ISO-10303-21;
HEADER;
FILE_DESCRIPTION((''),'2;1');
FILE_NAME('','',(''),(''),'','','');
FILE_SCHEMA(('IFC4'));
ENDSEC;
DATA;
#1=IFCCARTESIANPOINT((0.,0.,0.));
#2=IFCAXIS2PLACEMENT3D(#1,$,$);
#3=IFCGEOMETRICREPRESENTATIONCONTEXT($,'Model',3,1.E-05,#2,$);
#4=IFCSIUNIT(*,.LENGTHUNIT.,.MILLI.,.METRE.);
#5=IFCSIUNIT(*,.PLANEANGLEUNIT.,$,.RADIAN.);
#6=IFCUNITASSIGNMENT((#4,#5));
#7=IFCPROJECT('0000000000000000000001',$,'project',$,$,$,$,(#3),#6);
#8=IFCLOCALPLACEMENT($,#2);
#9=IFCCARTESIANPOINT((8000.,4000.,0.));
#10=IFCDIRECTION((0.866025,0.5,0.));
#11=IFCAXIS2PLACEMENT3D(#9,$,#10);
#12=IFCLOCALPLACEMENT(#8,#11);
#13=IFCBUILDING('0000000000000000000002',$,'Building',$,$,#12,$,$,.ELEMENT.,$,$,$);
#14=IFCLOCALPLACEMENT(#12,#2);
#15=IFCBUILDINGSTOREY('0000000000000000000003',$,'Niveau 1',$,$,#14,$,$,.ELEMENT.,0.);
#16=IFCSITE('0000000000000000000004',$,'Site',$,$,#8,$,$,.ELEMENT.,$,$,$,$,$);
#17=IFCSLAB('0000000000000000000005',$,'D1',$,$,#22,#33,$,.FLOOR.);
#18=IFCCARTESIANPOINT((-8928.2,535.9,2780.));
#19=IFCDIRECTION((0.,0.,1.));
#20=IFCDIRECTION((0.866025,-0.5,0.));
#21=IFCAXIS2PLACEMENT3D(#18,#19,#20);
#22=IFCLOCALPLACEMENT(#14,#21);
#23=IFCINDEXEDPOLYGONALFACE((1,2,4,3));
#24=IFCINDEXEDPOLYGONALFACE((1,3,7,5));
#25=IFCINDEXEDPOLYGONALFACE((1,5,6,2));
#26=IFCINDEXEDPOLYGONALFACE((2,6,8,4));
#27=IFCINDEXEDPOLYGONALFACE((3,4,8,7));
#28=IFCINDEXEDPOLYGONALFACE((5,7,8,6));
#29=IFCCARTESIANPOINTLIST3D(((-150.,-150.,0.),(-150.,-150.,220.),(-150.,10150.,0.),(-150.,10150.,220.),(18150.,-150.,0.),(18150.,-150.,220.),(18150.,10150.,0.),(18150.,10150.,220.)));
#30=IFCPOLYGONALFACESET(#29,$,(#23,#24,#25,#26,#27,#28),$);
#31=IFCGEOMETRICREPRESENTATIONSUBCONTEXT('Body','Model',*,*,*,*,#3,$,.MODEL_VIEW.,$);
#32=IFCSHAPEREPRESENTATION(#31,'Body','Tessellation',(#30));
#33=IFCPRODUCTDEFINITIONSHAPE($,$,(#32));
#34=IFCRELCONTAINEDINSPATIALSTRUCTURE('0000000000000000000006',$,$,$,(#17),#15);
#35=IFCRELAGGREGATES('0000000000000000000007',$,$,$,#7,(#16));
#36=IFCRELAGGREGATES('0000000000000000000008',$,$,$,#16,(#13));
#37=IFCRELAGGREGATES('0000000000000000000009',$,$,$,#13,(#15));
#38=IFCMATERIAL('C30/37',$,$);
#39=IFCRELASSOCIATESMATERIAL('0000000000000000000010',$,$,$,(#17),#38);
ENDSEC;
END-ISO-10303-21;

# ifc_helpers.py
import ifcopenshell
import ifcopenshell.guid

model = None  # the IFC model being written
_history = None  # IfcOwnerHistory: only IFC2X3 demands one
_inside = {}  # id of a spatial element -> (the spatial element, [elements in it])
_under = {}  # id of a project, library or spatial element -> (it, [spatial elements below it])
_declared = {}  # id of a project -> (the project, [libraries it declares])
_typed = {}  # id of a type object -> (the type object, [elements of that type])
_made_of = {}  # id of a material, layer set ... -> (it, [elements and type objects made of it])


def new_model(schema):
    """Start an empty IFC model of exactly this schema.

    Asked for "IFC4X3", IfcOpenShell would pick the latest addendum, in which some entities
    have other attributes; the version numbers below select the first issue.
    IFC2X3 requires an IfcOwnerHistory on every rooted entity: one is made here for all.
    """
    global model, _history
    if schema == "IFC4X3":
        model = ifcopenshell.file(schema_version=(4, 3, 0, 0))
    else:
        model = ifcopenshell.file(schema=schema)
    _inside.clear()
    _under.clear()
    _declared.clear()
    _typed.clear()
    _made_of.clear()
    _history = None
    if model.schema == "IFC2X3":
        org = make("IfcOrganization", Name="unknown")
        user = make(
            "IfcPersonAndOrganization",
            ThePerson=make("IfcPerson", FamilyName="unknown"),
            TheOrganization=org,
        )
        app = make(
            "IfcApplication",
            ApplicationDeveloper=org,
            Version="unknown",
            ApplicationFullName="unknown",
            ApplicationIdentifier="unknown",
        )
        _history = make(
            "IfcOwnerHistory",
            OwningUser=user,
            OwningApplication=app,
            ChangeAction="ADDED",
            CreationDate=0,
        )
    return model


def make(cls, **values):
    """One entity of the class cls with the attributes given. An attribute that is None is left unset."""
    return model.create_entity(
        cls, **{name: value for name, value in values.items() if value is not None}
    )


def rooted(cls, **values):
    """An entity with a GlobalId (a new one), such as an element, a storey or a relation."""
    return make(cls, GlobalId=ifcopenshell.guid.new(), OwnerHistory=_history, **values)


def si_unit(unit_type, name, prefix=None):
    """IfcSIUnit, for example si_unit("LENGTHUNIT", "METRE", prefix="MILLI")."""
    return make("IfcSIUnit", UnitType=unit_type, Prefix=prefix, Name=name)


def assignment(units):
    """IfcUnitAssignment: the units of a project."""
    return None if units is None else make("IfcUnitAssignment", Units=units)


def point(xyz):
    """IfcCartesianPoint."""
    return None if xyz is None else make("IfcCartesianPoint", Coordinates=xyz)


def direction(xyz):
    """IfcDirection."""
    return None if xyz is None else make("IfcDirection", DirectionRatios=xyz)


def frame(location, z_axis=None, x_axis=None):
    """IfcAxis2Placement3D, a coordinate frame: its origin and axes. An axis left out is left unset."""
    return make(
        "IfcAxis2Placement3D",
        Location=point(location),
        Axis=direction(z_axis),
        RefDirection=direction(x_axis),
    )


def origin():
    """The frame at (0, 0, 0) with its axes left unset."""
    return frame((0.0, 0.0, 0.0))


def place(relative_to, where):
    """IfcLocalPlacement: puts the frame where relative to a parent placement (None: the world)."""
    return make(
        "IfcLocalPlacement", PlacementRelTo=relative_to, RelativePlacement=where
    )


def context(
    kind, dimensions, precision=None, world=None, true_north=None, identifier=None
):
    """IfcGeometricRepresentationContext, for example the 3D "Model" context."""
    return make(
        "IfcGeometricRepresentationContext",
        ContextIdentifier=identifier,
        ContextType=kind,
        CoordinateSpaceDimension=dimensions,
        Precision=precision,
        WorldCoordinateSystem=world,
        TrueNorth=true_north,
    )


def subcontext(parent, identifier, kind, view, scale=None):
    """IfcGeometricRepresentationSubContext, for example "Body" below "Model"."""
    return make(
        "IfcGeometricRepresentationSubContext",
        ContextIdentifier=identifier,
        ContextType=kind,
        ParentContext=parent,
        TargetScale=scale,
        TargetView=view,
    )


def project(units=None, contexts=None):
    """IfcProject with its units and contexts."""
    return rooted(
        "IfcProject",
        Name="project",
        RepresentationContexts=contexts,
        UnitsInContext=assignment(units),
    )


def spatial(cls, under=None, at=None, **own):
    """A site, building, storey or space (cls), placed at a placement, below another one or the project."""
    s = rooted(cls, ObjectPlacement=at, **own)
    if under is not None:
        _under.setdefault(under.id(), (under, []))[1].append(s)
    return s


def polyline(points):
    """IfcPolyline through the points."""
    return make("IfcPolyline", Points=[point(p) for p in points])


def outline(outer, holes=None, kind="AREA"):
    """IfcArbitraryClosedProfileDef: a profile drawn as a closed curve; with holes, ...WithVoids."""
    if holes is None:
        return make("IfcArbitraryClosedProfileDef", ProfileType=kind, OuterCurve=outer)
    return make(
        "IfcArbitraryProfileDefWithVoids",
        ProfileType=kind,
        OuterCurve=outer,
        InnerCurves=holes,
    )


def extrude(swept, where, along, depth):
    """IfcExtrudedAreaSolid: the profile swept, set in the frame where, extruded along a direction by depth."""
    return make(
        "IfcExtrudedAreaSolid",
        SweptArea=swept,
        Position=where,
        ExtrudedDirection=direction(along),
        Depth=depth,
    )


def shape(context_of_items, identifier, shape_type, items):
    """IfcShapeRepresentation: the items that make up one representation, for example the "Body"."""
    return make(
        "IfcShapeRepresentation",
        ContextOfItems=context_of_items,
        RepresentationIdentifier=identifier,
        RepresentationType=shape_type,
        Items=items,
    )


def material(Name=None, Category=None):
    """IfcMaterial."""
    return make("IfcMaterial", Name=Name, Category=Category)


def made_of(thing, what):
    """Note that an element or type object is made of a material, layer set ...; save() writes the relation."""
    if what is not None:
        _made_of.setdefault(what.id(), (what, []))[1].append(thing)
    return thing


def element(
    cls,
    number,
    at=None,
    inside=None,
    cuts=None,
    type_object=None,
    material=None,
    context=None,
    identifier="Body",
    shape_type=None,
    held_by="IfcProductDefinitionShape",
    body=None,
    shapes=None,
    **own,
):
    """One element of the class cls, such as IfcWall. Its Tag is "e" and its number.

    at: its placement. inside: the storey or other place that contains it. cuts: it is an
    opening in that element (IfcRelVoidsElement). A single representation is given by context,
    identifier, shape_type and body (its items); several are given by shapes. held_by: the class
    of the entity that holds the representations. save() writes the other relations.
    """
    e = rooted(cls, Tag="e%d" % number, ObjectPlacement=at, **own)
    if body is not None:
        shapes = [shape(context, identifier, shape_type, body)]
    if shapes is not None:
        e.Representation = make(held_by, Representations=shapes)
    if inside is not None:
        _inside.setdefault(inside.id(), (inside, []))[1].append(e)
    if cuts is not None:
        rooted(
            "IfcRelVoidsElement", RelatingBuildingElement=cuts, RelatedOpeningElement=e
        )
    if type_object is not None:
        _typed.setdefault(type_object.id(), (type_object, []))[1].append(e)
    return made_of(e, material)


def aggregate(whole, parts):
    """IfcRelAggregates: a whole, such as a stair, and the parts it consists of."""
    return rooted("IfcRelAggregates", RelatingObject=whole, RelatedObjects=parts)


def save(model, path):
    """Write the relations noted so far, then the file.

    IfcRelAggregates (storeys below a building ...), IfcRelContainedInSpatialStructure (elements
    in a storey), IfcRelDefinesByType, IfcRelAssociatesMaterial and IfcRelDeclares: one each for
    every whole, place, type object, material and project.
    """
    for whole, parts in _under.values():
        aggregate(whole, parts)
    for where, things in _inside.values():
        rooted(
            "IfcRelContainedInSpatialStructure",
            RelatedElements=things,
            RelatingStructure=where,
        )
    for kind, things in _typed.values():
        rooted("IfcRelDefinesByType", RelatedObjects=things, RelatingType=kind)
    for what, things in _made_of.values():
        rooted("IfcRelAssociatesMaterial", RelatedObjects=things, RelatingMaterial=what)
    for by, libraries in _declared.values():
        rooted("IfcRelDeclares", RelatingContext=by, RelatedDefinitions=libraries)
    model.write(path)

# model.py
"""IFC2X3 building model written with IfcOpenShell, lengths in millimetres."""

from ifc_helpers import new_model, si_unit, frame, origin, place, context, subcontext, project, spatial, polyline, outline, extrude, material, element, save


model = new_model("IFC2X3")

# Units and contexts
model_context = context("Model", 3, precision=1e-05, world=origin())
body_context = subcontext(model_context, "Body", "Model", "MODEL_VIEW")
ifc_project = project(units=[si_unit("LENGTHUNIT", "METRE", prefix="MILLI"), si_unit("PLANEANGLEUNIT", "RADIAN")], contexts=[model_context])

# Site, building, storey
site_placement = place(None, origin())
site = spatial("IfcSite", under=ifc_project, at=site_placement, Name="Site", CompositionType="ELEMENT")
building_placement = place(site_placement, frame((8000.0, 4000.0, 0.0), x_axis=(0.866025, 0.5, 0.0)))
building = spatial("IfcBuilding", under=site, at=building_placement, Name="Building", CompositionType="ELEMENT")
storey_placement = place(building_placement, origin())
storey = spatial("IfcBuildingStorey", under=building, at=storey_placement, Name="Niveau 1", CompositionType="ELEMENT", Elevation=0.0)

# Shared definitions
ifc_material = material(Name="C30/37")

# Slab
slab_placement = place(storey_placement, frame((-8928.2, 535.9, 2780.0), z_axis=(0.0, 0.0, 1.0), x_axis=(0.866025, -0.5, 0.0)))
element("IfcSlab", 1, at=slab_placement, inside=storey, material=ifc_material, Name="D1", PredefinedType="FLOOR", context=body_context, shape_type="SweptSolid", body=[
    extrude(outline(polyline([(-150.0, -150.0), (18150.0, -150.0), (18150.0, 10150.0), (-150.0, 10150.0), (-150.0, -150.0)])), origin(), (0.0, 0.0, 1.0), 220.0),
])

save(model, "model.ifc")
